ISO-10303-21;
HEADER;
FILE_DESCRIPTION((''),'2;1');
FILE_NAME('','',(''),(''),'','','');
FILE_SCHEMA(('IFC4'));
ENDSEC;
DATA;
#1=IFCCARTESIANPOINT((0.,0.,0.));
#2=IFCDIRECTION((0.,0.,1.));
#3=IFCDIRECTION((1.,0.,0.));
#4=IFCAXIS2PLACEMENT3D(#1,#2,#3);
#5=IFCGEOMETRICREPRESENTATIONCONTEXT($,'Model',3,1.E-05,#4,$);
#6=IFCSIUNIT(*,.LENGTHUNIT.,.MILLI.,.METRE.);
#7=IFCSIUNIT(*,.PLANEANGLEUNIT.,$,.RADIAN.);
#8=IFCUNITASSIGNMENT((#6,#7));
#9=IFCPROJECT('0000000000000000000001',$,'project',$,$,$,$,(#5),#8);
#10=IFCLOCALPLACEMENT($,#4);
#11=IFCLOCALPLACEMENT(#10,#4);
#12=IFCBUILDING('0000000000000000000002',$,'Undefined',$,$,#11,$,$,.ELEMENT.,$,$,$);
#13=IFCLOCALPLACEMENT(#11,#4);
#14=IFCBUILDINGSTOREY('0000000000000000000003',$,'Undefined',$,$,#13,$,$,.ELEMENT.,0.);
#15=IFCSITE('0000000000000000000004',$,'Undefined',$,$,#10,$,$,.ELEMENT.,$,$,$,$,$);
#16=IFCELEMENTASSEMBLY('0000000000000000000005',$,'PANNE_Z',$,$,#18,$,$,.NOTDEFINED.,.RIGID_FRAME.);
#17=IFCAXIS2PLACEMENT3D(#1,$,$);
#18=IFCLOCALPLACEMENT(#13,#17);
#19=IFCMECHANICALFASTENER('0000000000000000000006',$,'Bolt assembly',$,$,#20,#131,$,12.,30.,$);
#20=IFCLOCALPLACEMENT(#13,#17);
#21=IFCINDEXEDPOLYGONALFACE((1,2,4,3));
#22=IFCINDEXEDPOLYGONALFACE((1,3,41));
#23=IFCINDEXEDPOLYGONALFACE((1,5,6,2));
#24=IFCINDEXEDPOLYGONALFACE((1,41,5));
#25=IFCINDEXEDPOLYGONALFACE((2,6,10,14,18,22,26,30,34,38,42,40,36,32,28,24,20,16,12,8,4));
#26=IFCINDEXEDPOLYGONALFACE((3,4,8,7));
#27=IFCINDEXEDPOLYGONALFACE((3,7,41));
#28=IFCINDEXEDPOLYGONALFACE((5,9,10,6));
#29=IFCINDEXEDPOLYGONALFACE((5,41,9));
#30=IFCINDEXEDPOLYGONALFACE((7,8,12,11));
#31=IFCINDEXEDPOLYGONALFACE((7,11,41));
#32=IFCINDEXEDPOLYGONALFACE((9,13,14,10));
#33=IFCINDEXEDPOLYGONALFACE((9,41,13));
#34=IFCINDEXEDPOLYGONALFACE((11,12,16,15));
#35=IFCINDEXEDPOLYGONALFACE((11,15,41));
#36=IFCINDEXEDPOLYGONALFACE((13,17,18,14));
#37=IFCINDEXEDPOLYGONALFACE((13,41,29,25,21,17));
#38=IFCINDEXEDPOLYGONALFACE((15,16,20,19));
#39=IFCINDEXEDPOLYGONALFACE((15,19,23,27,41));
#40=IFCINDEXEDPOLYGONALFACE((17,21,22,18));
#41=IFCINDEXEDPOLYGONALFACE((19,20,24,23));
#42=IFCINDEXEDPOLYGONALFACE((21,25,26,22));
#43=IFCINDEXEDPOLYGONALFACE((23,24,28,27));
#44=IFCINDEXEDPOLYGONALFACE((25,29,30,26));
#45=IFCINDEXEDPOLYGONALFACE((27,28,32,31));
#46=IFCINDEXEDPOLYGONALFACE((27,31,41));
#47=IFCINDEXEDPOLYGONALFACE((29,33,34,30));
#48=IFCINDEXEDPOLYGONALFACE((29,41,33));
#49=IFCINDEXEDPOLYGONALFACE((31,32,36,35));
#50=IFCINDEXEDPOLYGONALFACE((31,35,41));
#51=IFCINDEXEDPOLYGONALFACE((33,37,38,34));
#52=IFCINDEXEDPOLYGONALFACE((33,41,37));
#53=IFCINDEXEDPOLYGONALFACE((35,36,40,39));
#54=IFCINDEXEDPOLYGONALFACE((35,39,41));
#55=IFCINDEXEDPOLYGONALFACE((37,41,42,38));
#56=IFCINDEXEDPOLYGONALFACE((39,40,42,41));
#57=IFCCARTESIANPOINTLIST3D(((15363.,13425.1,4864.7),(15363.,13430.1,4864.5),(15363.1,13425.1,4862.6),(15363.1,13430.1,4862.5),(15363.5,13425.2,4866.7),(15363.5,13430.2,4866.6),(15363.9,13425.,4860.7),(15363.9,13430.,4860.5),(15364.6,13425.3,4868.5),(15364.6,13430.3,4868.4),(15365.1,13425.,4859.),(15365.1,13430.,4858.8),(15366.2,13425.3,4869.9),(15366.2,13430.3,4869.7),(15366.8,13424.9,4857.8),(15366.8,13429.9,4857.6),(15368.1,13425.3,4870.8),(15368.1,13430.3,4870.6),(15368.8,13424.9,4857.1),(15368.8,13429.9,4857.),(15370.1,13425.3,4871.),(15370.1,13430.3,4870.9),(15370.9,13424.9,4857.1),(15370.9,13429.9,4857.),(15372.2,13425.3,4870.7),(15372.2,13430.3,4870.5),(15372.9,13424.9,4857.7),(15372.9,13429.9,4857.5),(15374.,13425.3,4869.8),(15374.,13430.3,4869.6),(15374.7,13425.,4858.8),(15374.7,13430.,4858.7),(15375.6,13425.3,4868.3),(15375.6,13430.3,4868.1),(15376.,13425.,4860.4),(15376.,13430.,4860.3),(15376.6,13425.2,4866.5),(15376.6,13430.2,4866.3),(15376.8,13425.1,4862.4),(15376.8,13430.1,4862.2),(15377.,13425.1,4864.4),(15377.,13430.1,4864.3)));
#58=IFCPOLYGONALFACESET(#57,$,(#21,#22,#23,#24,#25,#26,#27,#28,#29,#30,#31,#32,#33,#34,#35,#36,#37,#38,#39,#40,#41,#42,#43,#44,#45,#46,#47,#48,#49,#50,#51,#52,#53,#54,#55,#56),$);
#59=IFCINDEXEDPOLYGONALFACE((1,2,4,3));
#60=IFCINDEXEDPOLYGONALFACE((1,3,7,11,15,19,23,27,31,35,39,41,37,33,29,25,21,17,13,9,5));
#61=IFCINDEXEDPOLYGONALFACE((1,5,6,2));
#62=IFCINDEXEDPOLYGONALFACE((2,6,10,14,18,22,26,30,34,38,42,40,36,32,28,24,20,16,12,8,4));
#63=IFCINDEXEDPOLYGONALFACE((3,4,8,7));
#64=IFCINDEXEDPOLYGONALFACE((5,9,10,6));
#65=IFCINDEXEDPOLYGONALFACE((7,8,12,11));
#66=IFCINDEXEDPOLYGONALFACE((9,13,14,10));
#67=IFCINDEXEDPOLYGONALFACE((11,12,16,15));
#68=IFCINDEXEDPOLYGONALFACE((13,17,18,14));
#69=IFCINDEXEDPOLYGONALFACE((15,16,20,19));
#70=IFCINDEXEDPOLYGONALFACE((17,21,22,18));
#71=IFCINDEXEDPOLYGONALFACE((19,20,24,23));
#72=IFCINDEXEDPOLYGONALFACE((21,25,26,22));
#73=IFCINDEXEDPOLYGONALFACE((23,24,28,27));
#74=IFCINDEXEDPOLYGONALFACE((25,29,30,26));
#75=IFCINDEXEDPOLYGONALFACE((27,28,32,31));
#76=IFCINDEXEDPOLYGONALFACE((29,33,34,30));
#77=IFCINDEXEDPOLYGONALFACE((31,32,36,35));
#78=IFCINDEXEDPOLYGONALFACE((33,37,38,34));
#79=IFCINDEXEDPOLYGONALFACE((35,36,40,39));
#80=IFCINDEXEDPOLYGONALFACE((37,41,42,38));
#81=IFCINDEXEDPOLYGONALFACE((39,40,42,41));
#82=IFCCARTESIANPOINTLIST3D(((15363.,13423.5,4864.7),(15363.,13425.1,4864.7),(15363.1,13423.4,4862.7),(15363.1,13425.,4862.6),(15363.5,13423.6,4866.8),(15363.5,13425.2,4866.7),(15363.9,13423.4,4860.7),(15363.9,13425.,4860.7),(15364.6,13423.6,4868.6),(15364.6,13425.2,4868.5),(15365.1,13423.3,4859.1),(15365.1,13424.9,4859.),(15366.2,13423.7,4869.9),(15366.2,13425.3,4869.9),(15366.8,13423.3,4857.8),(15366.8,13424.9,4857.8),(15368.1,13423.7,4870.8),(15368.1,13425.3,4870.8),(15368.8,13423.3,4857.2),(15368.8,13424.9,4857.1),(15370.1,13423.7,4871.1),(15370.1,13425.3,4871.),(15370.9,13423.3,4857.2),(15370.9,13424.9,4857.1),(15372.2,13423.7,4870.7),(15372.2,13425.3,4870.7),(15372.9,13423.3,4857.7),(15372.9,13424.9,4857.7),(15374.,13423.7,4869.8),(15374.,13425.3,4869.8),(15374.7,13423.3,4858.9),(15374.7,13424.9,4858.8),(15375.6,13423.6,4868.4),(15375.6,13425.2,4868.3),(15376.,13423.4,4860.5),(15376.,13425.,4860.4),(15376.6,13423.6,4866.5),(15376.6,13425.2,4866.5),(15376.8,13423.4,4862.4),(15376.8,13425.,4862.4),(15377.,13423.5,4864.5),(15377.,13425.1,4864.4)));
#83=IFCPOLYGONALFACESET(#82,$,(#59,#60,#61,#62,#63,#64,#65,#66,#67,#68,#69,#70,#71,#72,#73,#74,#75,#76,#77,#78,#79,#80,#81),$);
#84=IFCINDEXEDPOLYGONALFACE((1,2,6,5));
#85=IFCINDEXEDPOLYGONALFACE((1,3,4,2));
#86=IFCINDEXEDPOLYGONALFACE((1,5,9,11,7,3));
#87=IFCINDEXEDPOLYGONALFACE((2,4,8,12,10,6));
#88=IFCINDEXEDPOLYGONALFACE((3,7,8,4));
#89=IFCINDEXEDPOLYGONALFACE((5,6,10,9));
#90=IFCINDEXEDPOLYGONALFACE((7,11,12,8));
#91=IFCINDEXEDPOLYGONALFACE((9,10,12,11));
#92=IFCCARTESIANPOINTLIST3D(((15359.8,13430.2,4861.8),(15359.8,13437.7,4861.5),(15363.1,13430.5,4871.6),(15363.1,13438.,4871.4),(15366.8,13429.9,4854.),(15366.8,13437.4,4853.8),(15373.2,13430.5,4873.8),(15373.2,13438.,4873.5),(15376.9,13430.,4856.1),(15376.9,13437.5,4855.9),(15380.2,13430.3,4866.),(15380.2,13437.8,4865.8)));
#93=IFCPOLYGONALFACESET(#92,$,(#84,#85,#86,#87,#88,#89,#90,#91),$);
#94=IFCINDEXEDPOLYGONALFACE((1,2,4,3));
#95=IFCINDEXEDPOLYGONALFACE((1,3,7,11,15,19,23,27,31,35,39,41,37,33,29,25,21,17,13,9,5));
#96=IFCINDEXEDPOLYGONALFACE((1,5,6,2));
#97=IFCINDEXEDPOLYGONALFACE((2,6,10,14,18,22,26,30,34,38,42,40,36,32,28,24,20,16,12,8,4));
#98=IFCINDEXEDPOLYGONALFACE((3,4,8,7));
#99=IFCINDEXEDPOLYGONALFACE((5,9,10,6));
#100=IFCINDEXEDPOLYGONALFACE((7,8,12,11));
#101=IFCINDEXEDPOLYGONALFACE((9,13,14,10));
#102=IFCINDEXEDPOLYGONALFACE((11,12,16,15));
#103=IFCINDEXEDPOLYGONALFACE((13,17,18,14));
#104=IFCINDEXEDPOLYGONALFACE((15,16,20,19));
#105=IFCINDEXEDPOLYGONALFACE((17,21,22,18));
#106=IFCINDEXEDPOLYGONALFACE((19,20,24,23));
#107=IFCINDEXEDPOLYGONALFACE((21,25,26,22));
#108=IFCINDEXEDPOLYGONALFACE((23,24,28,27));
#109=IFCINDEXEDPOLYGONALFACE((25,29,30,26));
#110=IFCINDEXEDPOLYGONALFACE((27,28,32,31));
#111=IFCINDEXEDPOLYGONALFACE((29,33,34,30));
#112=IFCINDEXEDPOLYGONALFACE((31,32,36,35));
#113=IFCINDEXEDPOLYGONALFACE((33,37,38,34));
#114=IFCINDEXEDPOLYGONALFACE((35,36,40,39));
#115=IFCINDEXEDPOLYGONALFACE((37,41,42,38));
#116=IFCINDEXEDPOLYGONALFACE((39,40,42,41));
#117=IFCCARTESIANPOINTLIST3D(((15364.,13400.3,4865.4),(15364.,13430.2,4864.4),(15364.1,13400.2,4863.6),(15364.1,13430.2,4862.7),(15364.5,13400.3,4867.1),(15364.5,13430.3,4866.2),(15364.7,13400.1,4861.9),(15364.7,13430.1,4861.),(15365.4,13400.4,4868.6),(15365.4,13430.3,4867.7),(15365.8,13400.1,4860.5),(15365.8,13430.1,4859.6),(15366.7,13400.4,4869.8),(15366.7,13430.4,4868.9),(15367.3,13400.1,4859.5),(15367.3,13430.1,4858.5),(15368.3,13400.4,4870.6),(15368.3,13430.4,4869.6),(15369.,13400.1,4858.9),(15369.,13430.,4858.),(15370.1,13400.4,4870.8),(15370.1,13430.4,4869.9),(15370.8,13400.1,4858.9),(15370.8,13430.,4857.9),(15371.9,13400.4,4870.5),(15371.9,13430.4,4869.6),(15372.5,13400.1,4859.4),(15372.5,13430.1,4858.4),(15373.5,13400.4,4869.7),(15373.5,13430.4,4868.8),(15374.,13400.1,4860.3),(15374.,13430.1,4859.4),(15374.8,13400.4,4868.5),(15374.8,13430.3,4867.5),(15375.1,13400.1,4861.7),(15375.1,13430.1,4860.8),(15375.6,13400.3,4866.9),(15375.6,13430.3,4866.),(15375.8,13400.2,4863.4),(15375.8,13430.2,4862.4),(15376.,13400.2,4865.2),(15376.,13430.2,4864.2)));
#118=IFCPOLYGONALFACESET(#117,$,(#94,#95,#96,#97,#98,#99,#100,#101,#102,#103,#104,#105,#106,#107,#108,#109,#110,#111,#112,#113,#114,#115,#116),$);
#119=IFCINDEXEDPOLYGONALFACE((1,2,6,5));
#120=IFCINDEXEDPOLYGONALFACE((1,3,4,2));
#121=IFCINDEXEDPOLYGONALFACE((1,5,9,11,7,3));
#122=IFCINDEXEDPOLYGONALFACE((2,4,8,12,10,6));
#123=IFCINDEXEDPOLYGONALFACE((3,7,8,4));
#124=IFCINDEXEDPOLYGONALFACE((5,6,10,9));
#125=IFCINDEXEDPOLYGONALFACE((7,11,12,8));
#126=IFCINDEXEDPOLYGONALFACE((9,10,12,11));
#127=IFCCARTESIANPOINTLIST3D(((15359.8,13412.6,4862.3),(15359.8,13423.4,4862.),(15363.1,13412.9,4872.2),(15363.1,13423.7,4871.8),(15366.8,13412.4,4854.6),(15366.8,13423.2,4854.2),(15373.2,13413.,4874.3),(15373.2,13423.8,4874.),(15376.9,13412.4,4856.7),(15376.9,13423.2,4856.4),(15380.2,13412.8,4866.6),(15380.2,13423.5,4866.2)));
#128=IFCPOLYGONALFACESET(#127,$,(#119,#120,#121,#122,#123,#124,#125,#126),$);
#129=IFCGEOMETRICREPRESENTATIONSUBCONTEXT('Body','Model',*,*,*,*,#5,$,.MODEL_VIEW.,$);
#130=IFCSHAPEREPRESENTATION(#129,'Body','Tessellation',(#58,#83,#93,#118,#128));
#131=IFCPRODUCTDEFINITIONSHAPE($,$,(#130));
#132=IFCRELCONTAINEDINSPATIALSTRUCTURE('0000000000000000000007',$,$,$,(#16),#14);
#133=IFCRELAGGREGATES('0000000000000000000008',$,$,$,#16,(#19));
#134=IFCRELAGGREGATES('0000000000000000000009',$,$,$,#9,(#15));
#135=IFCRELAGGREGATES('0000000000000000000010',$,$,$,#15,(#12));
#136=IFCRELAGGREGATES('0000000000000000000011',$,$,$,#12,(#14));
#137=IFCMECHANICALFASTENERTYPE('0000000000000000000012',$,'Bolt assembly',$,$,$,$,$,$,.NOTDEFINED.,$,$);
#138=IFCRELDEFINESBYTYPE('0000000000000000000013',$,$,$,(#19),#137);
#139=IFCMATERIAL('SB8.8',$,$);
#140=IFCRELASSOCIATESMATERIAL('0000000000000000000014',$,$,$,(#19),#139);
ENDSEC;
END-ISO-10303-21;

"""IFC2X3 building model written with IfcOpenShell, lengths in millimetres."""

from ifc_helpers import new_model, si_unit, frame, origin_with_axes, origin_2d_with_axis, place, context, subcontext, project, spatial, polyline, circle, outline, extrude, source, transform, mapped, material, type_object, element, aggregate, save


model = new_model("IFC2X3")

# Units and contexts
model_context = context("Model", 3, precision=1e-05, world=origin_with_axes())
body_context = subcontext(model_context, "Body", "Model", "MODEL_VIEW")
ifc_project = project(units=[si_unit("LENGTHUNIT", "METRE", prefix="MILLI"), si_unit("PLANEANGLEUNIT", "RADIAN")], contexts=[model_context])

# Site, building, storey
site_placement = place(None, origin_with_axes())
site = spatial("IfcSite", under=ifc_project, at=site_placement, Name="Undefined", CompositionType="ELEMENT")
building_placement = place(site_placement, origin_with_axes())
building = spatial("IfcBuilding", under=site, at=building_placement, Name="Undefined", CompositionType="ELEMENT")
storey_placement = place(building_placement, origin_with_axes())
storey = spatial("IfcBuildingStorey", under=building, at=storey_placement, Name="Undefined", CompositionType="ELEMENT", Elevation=0.0)

# Shared definitions
ifc_material_1 = material(Name="SB8.8")
mechanical_fastener_type = type_object("IfcMechanicalFastenerType", Name="Bolt assembly")

# Element assembly, mechanical fastener
assembly_1_placement = place(storey_placement, origin_with_axes())
assembly_1 = element("IfcElementAssembly", 1, at=assembly_1_placement, inside=storey, Name="PANNE_Z", AssemblyPlace="NOTDEFINED", PredefinedType="RIGID_FRAME")
shared_shape_1 = source(origin_with_axes(), body_context, "Body", "SweptSolid", [
    extrude(circle(Radius=7.0, at=origin_2d_with_axis()), frame((0.0, -4.9, 0.0), z_axis=(0.0, 1.0, 0.0), x_axis=(1.0, 0.0, 0.0)), (0.0, 0.0, 1.0), 5.0),
    extrude(circle(Radius=7.0, at=origin_2d_with_axis()), frame((0.0, 0.1, 0.0), z_axis=(0.0, 1.0, 0.0), x_axis=(1.0, 0.0, 0.0)), (0.0, 0.0, 1.0), 1.6),
    extrude(outline(polyline([(10.4, 0.0), (5.2, 9.0), (-5.2, 9.0), (-10.4, 0.0), (-5.2, -9.0), (5.2, -9.0), (10.4, 0.0)])), frame((0.0, -12.5, 0.0), z_axis=(0.0, 1.0, 0.0), x_axis=(1.0, 0.0, 0.0)), (0.0, 0.0, 1.0), 7.5),
    extrude(circle(Radius=6.0, at=origin_2d_with_axis()), frame((0.0, -5.0, 0.0), z_axis=(0.0, 1.0, 0.0), x_axis=(1.0, 0.0, 0.0)), (0.0, 0.0, 1.0), 30.0),
    extrude(outline(polyline([(10.4, 0.0), (5.2, 9.0), (-5.2, 9.0), (-10.4, 0.0), (-5.2, -9.0), (5.2, -9.0), (10.4, 0.0)])), frame((0.0, 1.7, 0.0), z_axis=(0.0, 1.0, 0.0), x_axis=(1.0, 0.0, 0.0)), (0.0, 0.0, 1.0), 10.8),
])
mechanical_fastener_1_placement = place(assembly_1_placement, frame((15370.0, 13425.2, 4864.0), z_axis=(-0.745405, -0.020656, -0.666292), x_axis=(0.666612, -0.023097, -0.745047)))
mechanical_fastener_1 = element("IfcMechanicalFastener", 2, at=mechanical_fastener_1_placement, type_object=mechanical_fastener_type, material=ifc_material_1, Name="Bolt assembly", NominalDiameter=12.0, NominalLength=30.0, context=body_context, shape_type="MappedRepresentation", body=[
    mapped(shared_shape_1, transform((0.0, 0.0, 0.0))),
])
aggregate(assembly_1, [mechanical_fastener_1])

save(model, "model.ifc")
